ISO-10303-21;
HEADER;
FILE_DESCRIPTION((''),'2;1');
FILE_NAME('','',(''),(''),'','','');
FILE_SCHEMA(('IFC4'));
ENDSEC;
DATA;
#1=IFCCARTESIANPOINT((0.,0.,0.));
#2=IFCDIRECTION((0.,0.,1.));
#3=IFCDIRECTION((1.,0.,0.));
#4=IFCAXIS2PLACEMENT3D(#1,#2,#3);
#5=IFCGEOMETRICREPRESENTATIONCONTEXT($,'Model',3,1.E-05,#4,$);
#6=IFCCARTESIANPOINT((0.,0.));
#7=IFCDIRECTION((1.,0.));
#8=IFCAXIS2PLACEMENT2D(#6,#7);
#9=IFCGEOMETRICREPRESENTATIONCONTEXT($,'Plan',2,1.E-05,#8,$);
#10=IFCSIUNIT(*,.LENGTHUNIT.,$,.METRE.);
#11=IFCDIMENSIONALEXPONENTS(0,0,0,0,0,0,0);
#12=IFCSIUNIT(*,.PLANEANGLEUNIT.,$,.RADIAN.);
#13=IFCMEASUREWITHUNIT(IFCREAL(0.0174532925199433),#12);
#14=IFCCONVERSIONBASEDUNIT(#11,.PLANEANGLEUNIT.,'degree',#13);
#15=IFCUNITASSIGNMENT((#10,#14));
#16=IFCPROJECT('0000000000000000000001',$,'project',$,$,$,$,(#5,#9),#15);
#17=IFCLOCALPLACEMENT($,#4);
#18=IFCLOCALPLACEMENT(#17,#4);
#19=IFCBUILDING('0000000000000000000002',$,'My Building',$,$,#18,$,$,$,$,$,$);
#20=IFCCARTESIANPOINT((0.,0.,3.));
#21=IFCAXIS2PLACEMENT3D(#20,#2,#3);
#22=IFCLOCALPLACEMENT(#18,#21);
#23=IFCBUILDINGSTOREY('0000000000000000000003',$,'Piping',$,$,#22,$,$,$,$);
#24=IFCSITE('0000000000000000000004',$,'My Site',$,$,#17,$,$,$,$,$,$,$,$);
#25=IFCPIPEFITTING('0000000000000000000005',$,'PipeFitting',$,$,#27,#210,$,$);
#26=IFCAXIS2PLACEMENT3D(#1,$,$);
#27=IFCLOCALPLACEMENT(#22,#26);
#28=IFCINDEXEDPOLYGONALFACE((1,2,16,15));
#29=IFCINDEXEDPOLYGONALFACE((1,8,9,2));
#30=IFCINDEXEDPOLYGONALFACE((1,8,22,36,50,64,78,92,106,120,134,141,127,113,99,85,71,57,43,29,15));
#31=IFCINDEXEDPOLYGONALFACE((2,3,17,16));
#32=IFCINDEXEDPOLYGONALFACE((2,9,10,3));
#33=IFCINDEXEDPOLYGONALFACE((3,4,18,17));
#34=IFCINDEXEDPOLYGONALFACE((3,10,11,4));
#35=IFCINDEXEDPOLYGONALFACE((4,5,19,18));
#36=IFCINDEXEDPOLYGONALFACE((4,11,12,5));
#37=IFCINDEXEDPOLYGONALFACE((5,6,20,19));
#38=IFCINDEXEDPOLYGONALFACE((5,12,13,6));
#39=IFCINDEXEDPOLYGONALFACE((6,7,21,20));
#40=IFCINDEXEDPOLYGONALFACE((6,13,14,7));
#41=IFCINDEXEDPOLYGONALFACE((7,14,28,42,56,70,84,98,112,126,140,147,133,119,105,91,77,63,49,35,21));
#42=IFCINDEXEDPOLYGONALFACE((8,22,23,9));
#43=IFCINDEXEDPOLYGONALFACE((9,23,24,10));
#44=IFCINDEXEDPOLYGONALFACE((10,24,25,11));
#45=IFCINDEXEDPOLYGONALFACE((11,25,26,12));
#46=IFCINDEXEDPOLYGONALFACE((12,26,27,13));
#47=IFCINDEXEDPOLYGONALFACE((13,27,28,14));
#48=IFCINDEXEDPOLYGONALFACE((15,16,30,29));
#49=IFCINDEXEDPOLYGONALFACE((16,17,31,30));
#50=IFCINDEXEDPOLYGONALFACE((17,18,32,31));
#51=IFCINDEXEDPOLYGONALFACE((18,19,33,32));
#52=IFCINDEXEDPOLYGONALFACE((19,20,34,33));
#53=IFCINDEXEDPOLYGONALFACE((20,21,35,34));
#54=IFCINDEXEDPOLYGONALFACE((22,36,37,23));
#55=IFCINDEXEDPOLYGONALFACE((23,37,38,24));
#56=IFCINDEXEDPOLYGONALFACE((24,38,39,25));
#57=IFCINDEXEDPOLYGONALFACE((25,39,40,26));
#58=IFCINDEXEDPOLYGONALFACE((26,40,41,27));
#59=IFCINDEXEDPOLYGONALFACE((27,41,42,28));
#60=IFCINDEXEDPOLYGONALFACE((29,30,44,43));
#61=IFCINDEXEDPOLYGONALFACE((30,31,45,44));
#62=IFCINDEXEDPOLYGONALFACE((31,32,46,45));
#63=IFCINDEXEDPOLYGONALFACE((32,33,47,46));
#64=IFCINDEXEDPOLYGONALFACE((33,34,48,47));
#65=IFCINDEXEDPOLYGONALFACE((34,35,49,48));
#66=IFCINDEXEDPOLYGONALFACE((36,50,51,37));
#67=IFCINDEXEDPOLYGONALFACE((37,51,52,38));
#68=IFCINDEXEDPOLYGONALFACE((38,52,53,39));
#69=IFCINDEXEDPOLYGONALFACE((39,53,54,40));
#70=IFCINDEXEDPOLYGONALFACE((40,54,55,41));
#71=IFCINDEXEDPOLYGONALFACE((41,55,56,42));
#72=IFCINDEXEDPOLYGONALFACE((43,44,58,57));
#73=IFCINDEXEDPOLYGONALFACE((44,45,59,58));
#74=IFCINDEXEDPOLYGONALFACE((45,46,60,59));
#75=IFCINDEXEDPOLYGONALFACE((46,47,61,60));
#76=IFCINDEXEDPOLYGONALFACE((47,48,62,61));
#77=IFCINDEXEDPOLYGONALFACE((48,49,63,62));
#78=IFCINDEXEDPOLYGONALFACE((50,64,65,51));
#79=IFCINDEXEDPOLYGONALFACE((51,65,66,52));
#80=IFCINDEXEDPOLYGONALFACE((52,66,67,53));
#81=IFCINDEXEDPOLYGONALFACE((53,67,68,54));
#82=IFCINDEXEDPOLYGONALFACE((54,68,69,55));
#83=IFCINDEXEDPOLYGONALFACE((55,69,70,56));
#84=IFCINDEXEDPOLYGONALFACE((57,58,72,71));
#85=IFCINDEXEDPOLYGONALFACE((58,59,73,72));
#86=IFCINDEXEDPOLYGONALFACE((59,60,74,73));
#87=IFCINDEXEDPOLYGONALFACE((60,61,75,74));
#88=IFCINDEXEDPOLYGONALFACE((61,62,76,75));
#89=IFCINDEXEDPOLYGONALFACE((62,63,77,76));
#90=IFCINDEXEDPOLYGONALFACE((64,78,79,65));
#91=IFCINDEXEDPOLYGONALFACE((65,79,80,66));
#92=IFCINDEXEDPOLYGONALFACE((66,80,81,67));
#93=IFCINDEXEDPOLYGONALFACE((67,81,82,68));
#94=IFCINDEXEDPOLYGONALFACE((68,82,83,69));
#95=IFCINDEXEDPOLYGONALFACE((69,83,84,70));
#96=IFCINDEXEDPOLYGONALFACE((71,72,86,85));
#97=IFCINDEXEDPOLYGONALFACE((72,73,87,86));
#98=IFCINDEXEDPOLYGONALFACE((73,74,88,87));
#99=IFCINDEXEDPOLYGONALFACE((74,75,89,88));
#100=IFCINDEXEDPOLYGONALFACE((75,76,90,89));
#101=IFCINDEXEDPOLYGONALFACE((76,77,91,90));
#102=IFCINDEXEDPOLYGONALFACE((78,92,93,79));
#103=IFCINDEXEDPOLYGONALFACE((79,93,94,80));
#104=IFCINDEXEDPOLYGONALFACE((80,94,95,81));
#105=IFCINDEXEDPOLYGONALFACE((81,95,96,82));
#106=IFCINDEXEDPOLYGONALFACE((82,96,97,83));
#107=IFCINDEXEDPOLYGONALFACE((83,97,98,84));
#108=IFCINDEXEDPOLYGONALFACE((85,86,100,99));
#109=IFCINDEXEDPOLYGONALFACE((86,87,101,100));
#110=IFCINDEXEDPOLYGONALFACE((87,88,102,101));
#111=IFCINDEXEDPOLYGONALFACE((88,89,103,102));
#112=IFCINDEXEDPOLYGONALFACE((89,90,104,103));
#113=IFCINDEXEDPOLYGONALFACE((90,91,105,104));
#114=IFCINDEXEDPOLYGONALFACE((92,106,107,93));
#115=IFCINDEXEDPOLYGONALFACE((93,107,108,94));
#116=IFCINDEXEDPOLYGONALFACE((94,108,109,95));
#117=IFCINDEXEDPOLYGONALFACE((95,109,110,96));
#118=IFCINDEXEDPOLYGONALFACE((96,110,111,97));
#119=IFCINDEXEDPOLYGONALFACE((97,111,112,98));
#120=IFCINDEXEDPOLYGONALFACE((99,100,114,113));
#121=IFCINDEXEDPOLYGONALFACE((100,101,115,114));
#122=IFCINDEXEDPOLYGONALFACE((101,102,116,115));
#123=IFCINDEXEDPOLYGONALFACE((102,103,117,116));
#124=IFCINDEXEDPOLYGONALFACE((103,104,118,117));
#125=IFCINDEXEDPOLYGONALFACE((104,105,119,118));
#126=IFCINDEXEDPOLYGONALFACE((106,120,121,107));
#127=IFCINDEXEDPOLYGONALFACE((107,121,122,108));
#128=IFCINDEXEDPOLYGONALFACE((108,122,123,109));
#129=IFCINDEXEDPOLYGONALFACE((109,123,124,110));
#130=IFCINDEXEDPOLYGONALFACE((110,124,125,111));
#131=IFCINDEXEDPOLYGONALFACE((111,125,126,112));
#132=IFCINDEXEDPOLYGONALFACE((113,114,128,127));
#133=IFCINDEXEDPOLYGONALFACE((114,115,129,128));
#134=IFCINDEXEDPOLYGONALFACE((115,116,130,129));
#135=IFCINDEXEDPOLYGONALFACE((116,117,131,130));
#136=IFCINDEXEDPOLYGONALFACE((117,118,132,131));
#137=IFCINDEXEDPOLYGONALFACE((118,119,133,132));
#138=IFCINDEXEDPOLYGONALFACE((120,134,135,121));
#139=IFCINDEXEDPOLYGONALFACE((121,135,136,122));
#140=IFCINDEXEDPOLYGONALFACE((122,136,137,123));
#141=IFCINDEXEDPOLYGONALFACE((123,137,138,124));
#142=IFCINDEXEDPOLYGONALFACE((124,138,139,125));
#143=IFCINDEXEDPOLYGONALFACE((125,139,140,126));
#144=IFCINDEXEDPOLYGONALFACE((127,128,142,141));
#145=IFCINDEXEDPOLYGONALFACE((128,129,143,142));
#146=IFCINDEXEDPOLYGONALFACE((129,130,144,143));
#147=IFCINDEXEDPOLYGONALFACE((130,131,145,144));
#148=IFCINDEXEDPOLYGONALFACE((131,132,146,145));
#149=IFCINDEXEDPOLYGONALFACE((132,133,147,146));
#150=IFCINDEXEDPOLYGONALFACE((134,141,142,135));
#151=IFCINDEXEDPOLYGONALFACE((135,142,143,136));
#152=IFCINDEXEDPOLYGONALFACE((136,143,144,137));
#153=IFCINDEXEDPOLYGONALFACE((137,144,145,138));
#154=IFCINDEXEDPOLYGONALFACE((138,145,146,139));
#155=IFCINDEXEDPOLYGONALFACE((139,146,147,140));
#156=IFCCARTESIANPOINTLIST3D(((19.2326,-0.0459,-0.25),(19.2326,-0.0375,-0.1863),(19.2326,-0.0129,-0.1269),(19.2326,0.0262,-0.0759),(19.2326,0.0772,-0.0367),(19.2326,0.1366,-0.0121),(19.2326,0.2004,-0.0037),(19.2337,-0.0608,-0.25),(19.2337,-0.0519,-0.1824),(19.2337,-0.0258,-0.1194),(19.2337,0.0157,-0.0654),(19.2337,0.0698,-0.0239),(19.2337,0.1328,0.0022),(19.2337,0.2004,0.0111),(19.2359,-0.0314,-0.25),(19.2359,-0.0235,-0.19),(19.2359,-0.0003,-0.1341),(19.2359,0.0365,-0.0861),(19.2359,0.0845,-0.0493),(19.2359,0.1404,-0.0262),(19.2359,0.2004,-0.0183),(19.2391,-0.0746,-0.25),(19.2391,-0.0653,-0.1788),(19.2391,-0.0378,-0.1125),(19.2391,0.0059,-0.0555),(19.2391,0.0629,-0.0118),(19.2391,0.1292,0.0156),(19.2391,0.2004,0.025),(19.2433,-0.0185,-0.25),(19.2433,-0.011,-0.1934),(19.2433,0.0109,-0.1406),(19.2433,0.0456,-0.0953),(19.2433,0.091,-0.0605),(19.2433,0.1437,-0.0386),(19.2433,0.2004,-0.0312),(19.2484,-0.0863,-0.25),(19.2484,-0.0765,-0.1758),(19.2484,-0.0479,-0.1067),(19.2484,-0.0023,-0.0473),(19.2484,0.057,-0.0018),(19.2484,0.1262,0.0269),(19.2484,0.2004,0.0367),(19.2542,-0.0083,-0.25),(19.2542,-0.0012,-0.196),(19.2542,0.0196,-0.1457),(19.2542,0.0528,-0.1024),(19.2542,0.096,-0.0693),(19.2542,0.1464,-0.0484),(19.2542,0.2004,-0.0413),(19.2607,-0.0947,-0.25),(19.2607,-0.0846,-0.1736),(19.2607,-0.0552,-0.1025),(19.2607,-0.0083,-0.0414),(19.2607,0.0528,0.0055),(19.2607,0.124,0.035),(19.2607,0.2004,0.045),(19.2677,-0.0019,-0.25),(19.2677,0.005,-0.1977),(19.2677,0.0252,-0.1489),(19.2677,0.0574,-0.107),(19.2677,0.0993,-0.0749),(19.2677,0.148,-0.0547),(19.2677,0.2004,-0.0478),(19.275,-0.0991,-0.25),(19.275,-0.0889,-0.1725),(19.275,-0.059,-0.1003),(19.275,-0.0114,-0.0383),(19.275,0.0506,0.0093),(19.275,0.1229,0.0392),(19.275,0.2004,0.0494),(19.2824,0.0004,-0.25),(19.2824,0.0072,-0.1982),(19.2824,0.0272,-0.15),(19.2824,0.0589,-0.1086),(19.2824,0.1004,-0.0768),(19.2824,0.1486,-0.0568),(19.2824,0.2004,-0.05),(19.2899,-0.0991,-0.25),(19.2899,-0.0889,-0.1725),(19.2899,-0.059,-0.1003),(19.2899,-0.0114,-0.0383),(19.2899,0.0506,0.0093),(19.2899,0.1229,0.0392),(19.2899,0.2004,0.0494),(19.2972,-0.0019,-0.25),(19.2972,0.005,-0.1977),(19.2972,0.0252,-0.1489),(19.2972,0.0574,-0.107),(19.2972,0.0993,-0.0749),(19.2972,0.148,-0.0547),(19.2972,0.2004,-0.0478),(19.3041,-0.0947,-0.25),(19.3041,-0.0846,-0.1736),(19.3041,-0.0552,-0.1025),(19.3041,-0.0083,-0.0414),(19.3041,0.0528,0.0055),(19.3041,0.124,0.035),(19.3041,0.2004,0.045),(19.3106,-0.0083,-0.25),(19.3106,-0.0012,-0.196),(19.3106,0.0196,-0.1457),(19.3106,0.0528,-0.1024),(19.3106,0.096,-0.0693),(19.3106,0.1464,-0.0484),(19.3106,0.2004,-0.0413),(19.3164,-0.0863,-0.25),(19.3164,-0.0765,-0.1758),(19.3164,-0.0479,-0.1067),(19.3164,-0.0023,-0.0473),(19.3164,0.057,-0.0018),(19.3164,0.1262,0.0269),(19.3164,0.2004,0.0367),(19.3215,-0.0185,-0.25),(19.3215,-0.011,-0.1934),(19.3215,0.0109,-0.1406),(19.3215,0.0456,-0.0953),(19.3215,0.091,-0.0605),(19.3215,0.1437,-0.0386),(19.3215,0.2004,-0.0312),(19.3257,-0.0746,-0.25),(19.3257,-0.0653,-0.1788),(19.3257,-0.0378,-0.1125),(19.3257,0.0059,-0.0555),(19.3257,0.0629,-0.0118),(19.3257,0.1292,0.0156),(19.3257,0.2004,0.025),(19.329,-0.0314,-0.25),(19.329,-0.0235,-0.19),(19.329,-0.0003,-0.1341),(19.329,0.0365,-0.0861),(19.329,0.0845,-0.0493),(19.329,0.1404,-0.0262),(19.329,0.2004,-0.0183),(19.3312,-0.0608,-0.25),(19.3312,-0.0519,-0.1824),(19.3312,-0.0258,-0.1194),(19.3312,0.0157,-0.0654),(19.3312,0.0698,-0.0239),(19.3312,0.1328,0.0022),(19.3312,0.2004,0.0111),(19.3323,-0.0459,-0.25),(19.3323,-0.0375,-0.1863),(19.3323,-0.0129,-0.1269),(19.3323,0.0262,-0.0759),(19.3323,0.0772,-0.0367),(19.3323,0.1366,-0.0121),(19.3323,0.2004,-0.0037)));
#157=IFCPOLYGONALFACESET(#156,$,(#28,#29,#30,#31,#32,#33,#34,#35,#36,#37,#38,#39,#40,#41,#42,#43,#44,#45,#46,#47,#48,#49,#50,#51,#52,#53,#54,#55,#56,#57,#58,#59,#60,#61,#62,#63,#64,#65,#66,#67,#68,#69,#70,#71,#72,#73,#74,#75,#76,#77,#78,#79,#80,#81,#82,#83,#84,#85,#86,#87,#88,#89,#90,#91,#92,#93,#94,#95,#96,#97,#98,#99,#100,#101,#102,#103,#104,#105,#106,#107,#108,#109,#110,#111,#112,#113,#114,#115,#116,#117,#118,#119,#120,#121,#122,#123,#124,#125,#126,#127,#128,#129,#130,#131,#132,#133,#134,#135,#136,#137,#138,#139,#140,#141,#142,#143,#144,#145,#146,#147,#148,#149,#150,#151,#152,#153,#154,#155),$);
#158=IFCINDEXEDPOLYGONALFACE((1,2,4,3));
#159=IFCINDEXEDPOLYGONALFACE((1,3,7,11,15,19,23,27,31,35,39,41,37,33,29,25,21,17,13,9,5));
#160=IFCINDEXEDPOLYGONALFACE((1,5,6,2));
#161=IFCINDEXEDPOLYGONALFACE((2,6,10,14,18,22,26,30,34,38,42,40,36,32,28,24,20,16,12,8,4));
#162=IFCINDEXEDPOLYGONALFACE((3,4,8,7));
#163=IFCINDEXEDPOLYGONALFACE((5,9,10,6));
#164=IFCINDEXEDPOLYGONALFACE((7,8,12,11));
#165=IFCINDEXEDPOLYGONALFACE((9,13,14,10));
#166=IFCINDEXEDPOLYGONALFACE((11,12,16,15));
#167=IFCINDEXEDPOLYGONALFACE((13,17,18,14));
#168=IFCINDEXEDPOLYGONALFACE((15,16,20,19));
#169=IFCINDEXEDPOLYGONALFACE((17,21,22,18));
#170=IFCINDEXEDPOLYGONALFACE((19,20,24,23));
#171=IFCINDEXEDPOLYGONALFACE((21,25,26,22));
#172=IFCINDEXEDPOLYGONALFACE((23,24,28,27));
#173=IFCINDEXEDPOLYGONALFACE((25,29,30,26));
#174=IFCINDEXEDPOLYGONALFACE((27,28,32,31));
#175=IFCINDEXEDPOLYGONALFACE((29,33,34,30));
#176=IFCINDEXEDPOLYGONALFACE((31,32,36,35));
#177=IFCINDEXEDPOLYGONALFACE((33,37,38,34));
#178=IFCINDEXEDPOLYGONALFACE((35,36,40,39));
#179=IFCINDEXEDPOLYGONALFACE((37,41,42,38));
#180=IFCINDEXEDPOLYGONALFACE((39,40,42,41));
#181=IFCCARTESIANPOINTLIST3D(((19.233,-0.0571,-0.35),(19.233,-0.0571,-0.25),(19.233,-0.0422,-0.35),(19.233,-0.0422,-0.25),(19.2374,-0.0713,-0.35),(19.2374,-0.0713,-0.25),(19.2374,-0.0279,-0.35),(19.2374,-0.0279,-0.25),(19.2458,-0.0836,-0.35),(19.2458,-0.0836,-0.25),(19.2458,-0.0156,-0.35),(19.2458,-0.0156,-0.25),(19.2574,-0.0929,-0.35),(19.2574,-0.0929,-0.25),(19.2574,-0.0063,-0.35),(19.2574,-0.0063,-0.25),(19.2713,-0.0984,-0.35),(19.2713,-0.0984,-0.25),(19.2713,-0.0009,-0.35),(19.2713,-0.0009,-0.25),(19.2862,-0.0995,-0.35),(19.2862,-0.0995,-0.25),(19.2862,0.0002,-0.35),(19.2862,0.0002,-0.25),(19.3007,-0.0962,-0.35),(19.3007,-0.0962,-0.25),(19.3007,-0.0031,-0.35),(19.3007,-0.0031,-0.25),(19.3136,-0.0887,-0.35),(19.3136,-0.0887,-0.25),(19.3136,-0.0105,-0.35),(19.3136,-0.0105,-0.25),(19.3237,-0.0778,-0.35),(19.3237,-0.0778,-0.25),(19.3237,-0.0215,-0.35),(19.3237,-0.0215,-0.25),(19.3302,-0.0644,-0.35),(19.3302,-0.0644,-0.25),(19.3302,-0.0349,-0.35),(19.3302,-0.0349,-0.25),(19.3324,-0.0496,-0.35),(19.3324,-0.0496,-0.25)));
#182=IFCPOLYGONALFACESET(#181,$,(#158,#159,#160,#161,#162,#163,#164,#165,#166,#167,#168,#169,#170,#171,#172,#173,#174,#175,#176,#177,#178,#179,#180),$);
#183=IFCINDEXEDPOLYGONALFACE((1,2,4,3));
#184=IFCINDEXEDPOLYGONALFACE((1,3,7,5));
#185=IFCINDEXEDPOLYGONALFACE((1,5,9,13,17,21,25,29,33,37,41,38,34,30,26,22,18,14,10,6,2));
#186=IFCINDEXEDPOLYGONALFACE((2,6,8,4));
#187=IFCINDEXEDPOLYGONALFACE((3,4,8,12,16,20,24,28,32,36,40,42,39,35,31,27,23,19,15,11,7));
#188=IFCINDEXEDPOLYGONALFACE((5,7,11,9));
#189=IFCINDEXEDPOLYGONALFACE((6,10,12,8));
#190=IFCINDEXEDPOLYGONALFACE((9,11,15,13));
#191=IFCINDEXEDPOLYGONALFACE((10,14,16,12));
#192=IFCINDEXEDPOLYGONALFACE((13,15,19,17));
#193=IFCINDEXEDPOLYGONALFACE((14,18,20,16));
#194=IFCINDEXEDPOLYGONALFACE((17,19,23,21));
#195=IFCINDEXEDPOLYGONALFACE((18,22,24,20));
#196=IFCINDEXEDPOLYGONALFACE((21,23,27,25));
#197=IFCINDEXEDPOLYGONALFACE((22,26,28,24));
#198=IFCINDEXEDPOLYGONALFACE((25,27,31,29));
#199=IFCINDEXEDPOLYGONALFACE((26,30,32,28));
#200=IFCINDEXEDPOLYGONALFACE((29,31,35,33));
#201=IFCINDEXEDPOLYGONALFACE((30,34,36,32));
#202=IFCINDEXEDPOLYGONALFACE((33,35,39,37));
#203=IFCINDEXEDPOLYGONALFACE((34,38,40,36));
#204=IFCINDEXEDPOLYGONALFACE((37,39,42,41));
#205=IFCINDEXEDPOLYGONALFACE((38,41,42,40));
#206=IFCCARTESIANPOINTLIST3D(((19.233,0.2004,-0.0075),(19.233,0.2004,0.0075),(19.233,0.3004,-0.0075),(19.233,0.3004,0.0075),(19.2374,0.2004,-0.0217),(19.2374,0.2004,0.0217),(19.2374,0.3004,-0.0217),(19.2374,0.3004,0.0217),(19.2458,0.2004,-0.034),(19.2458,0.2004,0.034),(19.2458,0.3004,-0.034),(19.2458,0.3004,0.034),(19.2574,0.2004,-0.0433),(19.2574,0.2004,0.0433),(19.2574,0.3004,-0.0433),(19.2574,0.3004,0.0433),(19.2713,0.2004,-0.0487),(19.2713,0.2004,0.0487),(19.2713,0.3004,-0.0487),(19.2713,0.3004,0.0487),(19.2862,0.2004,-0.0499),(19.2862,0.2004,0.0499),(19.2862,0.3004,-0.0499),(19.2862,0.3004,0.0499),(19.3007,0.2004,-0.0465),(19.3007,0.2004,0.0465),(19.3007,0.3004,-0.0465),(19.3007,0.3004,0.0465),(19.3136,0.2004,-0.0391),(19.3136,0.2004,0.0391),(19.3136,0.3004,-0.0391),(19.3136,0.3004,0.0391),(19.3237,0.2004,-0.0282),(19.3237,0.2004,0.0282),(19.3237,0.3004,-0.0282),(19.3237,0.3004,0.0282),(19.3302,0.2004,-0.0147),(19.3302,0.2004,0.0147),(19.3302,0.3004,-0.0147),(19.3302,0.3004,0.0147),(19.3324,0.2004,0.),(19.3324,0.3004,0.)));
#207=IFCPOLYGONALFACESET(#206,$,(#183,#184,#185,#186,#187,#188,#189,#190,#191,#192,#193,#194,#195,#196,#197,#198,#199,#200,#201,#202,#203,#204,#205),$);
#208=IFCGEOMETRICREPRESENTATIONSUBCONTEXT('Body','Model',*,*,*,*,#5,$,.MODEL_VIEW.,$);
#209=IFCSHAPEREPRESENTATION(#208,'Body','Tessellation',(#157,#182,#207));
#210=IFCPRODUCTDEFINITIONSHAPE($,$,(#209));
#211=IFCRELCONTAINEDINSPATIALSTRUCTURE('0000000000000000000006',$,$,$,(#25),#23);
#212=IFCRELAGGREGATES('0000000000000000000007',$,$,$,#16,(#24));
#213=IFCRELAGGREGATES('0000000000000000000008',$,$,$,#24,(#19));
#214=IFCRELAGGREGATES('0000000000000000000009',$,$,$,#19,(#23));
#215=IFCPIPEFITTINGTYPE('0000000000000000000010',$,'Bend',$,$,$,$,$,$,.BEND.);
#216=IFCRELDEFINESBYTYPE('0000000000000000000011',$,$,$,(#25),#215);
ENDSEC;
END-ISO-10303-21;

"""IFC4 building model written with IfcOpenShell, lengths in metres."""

from ifc_helpers import new_model, entity, si_unit, converted_unit, frame, origin_with_axes, origin_2d_with_axis, place, context, subcontext, project, spatial, circle, extrude, source, transform, mapped, type_object, type_shapes, element, save


model = new_model("IFC4")

# Units and contexts
model_context = context("Model", 3, precision=1e-05, world=origin_with_axes())
plan_context = context("Plan", 2, precision=1e-05, world=origin_2d_with_axis())
body_context = subcontext(model_context, "Body", "Model", "MODEL_VIEW")
ifc_project = project(units=[si_unit("LENGTHUNIT", "METRE"), converted_unit("PLANEANGLEUNIT", "degree", entity("IfcReal", 0.0174532925199433), si_unit("PLANEANGLEUNIT", "RADIAN"), dimensions=[0, 0, 0, 0, 0, 0, 0])], contexts=[model_context, plan_context])

# Site, building, storey
site_placement = place(None, origin_with_axes())
site = spatial("IfcSite", under=ifc_project, at=site_placement, Name="My Site")
building_placement = place(site_placement, origin_with_axes())
building = spatial("IfcBuilding", under=site, at=building_placement, Name="My Building")
storey_placement = place(building_placement, frame((0.0, 0.0, 3.0), z_axis=(0.0, 0.0, 1.0), x_axis=(1.0, 0.0, 0.0)))
storey = spatial("IfcBuildingStorey", under=building, at=storey_placement, Name="Piping")

# Pipe fitting
pipe_fitting_type_1 = type_object("IfcPipeFittingType", Name="Bend", PredefinedType="BEND")
shared_shape = source(origin_with_axes(), body_context, "Body", "SolidModel", [
    entity("IfcSweptDiskSolid", entity("IfcIndexedPolyCurve", entity("IfcCartesianPointList3D", [[0.0, 0.0, -0.1], [0.0, -0.0732, -0.2768], [0.0, -0.25, -0.35]]), [entity("IfcArcIndex", [1, 2, 3])]), 0.05),
    extrude(circle(Radius=0.05), origin_with_axes(), (0.0, 0.0, -1.0), 0.1),
    extrude(circle(Radius=0.05), frame((0.0, -0.25, -0.35), z_axis=(0.0, -1.0, 0.0), x_axis=(1.0, 0.0, 0.0)), (0.0, 0.0, 1.0), 0.1),
])
type_shapes(pipe_fitting_type_1, [shared_shape])
for number, where, z_axis, x_axis, name in (
    (1, (19.2824, -0.0496, -0.35), (0.0, 0.0, -1.0), (1.0, 0.0, 0.0), "PipeFitting"),
):
    element("IfcPipeFitting", number, at=place(storey_placement, frame(where, z_axis=z_axis, x_axis=x_axis)), inside=storey, type_object=pipe_fitting_type_1, Name=name, context=body_context, shape_type="MappedRepresentation", body=[
        mapped(shared_shape, transform((0.0, 0.0, 0.0), x_axis=(1.0, 0.0, 0.0), y_axis=(0.0, 1.0, 0.0), z_axis=(0.0, 0.0, 1.0), scale=1.0)),
    ])

save(model, "model.ifc")
